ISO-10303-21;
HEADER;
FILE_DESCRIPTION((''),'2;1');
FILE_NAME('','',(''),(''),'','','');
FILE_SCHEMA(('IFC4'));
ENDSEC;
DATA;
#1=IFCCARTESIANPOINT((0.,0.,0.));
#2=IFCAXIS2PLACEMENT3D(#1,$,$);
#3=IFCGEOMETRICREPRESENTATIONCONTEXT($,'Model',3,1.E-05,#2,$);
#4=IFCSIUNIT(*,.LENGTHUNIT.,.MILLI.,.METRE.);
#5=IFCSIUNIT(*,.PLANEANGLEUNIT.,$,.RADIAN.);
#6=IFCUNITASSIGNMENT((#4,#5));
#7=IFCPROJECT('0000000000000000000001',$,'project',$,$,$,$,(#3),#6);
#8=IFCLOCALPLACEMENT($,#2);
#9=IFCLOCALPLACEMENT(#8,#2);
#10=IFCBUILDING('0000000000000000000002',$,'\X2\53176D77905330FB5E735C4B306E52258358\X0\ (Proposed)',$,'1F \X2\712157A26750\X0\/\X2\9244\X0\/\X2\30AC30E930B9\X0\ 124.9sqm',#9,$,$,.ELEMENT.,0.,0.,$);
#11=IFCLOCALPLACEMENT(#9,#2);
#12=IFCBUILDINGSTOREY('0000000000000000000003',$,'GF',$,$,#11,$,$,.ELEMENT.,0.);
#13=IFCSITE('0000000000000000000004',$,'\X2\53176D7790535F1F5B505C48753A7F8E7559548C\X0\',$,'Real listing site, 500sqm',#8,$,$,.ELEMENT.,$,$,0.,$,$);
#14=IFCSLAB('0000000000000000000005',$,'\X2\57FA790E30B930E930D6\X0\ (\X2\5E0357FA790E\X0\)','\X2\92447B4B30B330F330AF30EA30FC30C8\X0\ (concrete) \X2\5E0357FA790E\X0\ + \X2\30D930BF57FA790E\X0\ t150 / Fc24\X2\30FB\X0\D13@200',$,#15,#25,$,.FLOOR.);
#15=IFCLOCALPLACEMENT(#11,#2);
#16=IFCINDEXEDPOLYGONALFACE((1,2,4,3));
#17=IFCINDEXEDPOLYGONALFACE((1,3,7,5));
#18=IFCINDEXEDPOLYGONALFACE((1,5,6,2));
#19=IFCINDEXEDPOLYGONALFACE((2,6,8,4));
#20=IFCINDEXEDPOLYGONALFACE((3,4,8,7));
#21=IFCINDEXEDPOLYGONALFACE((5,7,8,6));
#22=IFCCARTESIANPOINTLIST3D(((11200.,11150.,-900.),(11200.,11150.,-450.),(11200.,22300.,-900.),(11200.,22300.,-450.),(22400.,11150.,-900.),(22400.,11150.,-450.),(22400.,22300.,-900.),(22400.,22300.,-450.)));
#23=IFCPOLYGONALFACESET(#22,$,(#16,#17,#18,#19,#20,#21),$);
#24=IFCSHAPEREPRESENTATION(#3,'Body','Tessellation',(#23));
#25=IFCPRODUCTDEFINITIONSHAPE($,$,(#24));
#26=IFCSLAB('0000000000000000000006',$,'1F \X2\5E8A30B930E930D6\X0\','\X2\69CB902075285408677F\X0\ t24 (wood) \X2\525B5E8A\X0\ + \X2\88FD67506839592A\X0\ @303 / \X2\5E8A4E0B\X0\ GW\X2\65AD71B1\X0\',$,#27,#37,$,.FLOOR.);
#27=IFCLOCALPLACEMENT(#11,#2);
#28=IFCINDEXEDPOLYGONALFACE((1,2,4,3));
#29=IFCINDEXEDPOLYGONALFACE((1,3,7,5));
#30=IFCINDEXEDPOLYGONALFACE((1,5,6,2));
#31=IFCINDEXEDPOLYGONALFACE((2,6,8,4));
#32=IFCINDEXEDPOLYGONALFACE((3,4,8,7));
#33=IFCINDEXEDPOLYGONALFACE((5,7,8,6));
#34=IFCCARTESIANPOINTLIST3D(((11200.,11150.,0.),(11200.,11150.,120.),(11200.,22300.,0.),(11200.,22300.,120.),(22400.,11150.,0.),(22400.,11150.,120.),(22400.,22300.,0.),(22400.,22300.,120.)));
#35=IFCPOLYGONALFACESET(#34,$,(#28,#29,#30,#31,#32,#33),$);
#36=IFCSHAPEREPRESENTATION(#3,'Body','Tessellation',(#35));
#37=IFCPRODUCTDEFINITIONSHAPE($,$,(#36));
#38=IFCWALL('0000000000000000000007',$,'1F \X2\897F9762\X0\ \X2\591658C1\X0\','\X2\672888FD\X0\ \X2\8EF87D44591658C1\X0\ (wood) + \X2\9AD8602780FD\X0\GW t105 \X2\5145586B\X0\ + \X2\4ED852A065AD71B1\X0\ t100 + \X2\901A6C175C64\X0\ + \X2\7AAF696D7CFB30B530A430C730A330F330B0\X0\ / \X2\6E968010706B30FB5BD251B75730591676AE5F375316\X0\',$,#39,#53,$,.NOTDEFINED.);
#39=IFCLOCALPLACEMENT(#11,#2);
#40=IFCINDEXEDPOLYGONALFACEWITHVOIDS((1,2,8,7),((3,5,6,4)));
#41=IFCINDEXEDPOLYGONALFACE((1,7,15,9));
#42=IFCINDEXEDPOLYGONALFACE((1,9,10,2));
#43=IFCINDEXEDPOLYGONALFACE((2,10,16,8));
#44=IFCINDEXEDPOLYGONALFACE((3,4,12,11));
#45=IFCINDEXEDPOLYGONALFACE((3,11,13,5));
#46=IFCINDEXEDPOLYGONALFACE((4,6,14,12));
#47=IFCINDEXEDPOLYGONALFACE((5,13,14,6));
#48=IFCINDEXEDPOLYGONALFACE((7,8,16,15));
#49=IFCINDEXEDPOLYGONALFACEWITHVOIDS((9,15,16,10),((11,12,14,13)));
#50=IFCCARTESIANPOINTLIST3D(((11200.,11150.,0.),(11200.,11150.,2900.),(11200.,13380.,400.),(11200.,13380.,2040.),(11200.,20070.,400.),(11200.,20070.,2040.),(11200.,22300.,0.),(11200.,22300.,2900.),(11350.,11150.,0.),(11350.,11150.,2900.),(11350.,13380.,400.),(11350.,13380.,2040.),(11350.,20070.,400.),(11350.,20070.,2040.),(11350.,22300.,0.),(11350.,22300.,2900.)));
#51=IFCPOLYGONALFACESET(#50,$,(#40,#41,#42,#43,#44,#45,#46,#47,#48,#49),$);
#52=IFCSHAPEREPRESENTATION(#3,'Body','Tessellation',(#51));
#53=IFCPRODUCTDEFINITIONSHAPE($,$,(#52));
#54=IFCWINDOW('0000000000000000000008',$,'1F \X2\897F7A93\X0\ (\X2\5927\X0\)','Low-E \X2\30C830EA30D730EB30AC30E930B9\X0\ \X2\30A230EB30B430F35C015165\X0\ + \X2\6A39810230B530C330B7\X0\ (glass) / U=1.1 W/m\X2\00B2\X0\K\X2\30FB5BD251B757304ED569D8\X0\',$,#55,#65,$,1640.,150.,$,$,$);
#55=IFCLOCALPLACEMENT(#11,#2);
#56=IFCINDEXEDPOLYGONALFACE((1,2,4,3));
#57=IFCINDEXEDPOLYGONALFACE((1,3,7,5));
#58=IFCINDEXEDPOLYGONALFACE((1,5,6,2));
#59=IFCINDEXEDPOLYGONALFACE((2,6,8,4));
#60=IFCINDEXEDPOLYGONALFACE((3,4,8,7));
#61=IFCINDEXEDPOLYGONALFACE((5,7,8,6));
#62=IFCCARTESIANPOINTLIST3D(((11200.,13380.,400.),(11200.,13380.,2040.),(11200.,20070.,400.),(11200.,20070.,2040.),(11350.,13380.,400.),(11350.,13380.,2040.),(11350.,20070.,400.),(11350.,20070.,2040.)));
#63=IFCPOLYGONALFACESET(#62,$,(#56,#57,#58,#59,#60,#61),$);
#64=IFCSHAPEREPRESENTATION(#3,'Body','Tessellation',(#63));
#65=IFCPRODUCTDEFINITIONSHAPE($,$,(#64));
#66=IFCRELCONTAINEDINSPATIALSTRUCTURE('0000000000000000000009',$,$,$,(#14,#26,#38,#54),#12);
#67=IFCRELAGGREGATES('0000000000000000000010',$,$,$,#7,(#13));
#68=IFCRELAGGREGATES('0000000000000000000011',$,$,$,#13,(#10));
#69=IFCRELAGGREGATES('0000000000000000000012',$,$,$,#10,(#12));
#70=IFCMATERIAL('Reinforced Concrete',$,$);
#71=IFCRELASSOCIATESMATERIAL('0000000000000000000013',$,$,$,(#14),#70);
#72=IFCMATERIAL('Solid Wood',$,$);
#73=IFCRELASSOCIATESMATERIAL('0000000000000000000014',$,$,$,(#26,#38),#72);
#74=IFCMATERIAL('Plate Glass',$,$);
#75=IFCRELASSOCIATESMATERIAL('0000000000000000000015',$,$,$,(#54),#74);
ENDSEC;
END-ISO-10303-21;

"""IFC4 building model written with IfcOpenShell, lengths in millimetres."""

from ifc_helpers import new_model, si_unit, frame, frame_2d, origin, place, context, project, spatial, rectangle, extrude, material, element, fill, save


model = new_model("IFC4")

# Units and contexts
model_context = context("Model", 3, precision=1e-05, world=origin())
ifc_project = project(units=[si_unit("LENGTHUNIT", "METRE", prefix="MILLI"), si_unit("PLANEANGLEUNIT", "RADIAN")], contexts=[model_context])

# Site, building, storey
site_placement = place(None, origin())
site = spatial("IfcSite", under=ifc_project, at=site_placement, Name="北海道弟子屈町美留和", ObjectType="Real listing site, 500sqm", CompositionType="ELEMENT", RefElevation=0.0)
building_placement = place(site_placement, origin())
building = spatial("IfcBuilding", under=site, at=building_placement, Name="北海道・平屋の別荘 (Proposed)", ObjectType="1F 無垢材/鉄/ガラス 124.9sqm", CompositionType="ELEMENT", ElevationOfRefHeight=0.0, ElevationOfTerrain=0.0)
storey_placement = place(building_placement, origin())
storey = spatial("IfcBuildingStorey", under=building, at=storey_placement, Name="GF", CompositionType="ELEMENT", Elevation=0.0)

# Shared definitions
ifc_material_1 = material(Name="Solid Wood")

# Slabs
ifc_material_2 = material(Name="Reinforced Concrete")
slab_1_placement = place(storey_placement, frame((5600.0, 5575.0, -450.0)))
element("IfcSlab", 1, at=slab_1_placement, inside=storey, material=ifc_material_2, Name="基礎スラブ (布基礎)", Description="鉄筋コンクリート (concrete) 布基礎 + ベタ基礎 t150 / Fc24・D13@200", PredefinedType="FLOOR", context=model_context, shape_type="SweptSolid", body=[
    extrude(rectangle(XDim=11200.0, YDim=11150.0, at=frame_2d((5600.0, 5575.0))), frame((5600.0, 5575.0, -450.0)), (0.0, 0.0, 1.0), 450.0),
])
slab_2_placement = place(storey_placement, frame((5600.0, 5575.0, 0.0)))
element("IfcSlab", 2, at=slab_2_placement, inside=storey, material=ifc_material_1, Name="1F 床スラブ", Description="構造用合板 t24 (wood) 剛床 + 製材根太 @303 / 床下 GW断熱", PredefinedType="FLOOR", context=model_context, shape_type="SweptSolid", body=[
    extrude(rectangle(XDim=11200.0, YDim=11150.0, at=frame_2d((5600.0, 5575.0))), frame((5600.0, 5575.0, 0.0)), (0.0, 0.0, 1.0), 120.0),
])

# Shared definitions
ifc_material_3 = material(Name="Plate Glass")

# Wall, opening, window
wall_1_placement = place(storey_placement, frame((5600.0, 5575.0, 0.0)))
wall_1 = element("IfcWall", 3, at=wall_1_placement, inside=storey, material=ifc_material_1, Name="1F 西面 外壁", Description="木製 軸組外壁 (wood) + 高性能GW t105 充填 + 付加断熱 t100 + 通気層 + 窯業系サイディング / 準耐火・寒冷地外皮強化", PredefinedType="NOTDEFINED", context=model_context, shape_type="SweptSolid", body=[
    extrude(rectangle(XDim=150.0, YDim=11150.0, at=frame_2d((75.0, 5575.0))), frame((5600.0, 5575.0, 0.0)), (0.0, 0.0, 1.0), 2900.0),
])
opening_1_placement = place(storey_placement, frame((5600.0, 6690.0, 200.0)))
opening_1 = element("IfcOpeningElement", 4, at=opening_1_placement, cuts=wall_1, PredefinedType="NOTDEFINED", context=model_context, shape_type="SweptSolid", body=[
    extrude(rectangle(XDim=150.0, YDim=6690.0, at=frame_2d((75.0, 3345.0))), frame((5600.0, 6690.0, 200.0)), (0.0, 0.0, 1.0), 1640.0),
])
window_1_placement = place(storey_placement, frame((5600.0, 6690.0, 200.0)))
window_1 = element("IfcWindow", 5, at=window_1_placement, inside=storey, material=ifc_material_3, Name="1F 西窓 (大)", Description="Low-E トリプルガラス アルゴン封入 + 樹脂サッシ (glass) / U=1.1 W/m²K・寒冷地仕様", OverallHeight=1640.0, OverallWidth=150.0, context=model_context, shape_type="SweptSolid", body=[
    extrude(rectangle(XDim=150.0, YDim=6690.0, at=frame_2d((75.0, 3345.0))), frame((5600.0, 6690.0, 200.0)), (0.0, 0.0, 1.0), 1640.0),
])
fill(opening_1, window_1)

save(model, "model.ifc")
